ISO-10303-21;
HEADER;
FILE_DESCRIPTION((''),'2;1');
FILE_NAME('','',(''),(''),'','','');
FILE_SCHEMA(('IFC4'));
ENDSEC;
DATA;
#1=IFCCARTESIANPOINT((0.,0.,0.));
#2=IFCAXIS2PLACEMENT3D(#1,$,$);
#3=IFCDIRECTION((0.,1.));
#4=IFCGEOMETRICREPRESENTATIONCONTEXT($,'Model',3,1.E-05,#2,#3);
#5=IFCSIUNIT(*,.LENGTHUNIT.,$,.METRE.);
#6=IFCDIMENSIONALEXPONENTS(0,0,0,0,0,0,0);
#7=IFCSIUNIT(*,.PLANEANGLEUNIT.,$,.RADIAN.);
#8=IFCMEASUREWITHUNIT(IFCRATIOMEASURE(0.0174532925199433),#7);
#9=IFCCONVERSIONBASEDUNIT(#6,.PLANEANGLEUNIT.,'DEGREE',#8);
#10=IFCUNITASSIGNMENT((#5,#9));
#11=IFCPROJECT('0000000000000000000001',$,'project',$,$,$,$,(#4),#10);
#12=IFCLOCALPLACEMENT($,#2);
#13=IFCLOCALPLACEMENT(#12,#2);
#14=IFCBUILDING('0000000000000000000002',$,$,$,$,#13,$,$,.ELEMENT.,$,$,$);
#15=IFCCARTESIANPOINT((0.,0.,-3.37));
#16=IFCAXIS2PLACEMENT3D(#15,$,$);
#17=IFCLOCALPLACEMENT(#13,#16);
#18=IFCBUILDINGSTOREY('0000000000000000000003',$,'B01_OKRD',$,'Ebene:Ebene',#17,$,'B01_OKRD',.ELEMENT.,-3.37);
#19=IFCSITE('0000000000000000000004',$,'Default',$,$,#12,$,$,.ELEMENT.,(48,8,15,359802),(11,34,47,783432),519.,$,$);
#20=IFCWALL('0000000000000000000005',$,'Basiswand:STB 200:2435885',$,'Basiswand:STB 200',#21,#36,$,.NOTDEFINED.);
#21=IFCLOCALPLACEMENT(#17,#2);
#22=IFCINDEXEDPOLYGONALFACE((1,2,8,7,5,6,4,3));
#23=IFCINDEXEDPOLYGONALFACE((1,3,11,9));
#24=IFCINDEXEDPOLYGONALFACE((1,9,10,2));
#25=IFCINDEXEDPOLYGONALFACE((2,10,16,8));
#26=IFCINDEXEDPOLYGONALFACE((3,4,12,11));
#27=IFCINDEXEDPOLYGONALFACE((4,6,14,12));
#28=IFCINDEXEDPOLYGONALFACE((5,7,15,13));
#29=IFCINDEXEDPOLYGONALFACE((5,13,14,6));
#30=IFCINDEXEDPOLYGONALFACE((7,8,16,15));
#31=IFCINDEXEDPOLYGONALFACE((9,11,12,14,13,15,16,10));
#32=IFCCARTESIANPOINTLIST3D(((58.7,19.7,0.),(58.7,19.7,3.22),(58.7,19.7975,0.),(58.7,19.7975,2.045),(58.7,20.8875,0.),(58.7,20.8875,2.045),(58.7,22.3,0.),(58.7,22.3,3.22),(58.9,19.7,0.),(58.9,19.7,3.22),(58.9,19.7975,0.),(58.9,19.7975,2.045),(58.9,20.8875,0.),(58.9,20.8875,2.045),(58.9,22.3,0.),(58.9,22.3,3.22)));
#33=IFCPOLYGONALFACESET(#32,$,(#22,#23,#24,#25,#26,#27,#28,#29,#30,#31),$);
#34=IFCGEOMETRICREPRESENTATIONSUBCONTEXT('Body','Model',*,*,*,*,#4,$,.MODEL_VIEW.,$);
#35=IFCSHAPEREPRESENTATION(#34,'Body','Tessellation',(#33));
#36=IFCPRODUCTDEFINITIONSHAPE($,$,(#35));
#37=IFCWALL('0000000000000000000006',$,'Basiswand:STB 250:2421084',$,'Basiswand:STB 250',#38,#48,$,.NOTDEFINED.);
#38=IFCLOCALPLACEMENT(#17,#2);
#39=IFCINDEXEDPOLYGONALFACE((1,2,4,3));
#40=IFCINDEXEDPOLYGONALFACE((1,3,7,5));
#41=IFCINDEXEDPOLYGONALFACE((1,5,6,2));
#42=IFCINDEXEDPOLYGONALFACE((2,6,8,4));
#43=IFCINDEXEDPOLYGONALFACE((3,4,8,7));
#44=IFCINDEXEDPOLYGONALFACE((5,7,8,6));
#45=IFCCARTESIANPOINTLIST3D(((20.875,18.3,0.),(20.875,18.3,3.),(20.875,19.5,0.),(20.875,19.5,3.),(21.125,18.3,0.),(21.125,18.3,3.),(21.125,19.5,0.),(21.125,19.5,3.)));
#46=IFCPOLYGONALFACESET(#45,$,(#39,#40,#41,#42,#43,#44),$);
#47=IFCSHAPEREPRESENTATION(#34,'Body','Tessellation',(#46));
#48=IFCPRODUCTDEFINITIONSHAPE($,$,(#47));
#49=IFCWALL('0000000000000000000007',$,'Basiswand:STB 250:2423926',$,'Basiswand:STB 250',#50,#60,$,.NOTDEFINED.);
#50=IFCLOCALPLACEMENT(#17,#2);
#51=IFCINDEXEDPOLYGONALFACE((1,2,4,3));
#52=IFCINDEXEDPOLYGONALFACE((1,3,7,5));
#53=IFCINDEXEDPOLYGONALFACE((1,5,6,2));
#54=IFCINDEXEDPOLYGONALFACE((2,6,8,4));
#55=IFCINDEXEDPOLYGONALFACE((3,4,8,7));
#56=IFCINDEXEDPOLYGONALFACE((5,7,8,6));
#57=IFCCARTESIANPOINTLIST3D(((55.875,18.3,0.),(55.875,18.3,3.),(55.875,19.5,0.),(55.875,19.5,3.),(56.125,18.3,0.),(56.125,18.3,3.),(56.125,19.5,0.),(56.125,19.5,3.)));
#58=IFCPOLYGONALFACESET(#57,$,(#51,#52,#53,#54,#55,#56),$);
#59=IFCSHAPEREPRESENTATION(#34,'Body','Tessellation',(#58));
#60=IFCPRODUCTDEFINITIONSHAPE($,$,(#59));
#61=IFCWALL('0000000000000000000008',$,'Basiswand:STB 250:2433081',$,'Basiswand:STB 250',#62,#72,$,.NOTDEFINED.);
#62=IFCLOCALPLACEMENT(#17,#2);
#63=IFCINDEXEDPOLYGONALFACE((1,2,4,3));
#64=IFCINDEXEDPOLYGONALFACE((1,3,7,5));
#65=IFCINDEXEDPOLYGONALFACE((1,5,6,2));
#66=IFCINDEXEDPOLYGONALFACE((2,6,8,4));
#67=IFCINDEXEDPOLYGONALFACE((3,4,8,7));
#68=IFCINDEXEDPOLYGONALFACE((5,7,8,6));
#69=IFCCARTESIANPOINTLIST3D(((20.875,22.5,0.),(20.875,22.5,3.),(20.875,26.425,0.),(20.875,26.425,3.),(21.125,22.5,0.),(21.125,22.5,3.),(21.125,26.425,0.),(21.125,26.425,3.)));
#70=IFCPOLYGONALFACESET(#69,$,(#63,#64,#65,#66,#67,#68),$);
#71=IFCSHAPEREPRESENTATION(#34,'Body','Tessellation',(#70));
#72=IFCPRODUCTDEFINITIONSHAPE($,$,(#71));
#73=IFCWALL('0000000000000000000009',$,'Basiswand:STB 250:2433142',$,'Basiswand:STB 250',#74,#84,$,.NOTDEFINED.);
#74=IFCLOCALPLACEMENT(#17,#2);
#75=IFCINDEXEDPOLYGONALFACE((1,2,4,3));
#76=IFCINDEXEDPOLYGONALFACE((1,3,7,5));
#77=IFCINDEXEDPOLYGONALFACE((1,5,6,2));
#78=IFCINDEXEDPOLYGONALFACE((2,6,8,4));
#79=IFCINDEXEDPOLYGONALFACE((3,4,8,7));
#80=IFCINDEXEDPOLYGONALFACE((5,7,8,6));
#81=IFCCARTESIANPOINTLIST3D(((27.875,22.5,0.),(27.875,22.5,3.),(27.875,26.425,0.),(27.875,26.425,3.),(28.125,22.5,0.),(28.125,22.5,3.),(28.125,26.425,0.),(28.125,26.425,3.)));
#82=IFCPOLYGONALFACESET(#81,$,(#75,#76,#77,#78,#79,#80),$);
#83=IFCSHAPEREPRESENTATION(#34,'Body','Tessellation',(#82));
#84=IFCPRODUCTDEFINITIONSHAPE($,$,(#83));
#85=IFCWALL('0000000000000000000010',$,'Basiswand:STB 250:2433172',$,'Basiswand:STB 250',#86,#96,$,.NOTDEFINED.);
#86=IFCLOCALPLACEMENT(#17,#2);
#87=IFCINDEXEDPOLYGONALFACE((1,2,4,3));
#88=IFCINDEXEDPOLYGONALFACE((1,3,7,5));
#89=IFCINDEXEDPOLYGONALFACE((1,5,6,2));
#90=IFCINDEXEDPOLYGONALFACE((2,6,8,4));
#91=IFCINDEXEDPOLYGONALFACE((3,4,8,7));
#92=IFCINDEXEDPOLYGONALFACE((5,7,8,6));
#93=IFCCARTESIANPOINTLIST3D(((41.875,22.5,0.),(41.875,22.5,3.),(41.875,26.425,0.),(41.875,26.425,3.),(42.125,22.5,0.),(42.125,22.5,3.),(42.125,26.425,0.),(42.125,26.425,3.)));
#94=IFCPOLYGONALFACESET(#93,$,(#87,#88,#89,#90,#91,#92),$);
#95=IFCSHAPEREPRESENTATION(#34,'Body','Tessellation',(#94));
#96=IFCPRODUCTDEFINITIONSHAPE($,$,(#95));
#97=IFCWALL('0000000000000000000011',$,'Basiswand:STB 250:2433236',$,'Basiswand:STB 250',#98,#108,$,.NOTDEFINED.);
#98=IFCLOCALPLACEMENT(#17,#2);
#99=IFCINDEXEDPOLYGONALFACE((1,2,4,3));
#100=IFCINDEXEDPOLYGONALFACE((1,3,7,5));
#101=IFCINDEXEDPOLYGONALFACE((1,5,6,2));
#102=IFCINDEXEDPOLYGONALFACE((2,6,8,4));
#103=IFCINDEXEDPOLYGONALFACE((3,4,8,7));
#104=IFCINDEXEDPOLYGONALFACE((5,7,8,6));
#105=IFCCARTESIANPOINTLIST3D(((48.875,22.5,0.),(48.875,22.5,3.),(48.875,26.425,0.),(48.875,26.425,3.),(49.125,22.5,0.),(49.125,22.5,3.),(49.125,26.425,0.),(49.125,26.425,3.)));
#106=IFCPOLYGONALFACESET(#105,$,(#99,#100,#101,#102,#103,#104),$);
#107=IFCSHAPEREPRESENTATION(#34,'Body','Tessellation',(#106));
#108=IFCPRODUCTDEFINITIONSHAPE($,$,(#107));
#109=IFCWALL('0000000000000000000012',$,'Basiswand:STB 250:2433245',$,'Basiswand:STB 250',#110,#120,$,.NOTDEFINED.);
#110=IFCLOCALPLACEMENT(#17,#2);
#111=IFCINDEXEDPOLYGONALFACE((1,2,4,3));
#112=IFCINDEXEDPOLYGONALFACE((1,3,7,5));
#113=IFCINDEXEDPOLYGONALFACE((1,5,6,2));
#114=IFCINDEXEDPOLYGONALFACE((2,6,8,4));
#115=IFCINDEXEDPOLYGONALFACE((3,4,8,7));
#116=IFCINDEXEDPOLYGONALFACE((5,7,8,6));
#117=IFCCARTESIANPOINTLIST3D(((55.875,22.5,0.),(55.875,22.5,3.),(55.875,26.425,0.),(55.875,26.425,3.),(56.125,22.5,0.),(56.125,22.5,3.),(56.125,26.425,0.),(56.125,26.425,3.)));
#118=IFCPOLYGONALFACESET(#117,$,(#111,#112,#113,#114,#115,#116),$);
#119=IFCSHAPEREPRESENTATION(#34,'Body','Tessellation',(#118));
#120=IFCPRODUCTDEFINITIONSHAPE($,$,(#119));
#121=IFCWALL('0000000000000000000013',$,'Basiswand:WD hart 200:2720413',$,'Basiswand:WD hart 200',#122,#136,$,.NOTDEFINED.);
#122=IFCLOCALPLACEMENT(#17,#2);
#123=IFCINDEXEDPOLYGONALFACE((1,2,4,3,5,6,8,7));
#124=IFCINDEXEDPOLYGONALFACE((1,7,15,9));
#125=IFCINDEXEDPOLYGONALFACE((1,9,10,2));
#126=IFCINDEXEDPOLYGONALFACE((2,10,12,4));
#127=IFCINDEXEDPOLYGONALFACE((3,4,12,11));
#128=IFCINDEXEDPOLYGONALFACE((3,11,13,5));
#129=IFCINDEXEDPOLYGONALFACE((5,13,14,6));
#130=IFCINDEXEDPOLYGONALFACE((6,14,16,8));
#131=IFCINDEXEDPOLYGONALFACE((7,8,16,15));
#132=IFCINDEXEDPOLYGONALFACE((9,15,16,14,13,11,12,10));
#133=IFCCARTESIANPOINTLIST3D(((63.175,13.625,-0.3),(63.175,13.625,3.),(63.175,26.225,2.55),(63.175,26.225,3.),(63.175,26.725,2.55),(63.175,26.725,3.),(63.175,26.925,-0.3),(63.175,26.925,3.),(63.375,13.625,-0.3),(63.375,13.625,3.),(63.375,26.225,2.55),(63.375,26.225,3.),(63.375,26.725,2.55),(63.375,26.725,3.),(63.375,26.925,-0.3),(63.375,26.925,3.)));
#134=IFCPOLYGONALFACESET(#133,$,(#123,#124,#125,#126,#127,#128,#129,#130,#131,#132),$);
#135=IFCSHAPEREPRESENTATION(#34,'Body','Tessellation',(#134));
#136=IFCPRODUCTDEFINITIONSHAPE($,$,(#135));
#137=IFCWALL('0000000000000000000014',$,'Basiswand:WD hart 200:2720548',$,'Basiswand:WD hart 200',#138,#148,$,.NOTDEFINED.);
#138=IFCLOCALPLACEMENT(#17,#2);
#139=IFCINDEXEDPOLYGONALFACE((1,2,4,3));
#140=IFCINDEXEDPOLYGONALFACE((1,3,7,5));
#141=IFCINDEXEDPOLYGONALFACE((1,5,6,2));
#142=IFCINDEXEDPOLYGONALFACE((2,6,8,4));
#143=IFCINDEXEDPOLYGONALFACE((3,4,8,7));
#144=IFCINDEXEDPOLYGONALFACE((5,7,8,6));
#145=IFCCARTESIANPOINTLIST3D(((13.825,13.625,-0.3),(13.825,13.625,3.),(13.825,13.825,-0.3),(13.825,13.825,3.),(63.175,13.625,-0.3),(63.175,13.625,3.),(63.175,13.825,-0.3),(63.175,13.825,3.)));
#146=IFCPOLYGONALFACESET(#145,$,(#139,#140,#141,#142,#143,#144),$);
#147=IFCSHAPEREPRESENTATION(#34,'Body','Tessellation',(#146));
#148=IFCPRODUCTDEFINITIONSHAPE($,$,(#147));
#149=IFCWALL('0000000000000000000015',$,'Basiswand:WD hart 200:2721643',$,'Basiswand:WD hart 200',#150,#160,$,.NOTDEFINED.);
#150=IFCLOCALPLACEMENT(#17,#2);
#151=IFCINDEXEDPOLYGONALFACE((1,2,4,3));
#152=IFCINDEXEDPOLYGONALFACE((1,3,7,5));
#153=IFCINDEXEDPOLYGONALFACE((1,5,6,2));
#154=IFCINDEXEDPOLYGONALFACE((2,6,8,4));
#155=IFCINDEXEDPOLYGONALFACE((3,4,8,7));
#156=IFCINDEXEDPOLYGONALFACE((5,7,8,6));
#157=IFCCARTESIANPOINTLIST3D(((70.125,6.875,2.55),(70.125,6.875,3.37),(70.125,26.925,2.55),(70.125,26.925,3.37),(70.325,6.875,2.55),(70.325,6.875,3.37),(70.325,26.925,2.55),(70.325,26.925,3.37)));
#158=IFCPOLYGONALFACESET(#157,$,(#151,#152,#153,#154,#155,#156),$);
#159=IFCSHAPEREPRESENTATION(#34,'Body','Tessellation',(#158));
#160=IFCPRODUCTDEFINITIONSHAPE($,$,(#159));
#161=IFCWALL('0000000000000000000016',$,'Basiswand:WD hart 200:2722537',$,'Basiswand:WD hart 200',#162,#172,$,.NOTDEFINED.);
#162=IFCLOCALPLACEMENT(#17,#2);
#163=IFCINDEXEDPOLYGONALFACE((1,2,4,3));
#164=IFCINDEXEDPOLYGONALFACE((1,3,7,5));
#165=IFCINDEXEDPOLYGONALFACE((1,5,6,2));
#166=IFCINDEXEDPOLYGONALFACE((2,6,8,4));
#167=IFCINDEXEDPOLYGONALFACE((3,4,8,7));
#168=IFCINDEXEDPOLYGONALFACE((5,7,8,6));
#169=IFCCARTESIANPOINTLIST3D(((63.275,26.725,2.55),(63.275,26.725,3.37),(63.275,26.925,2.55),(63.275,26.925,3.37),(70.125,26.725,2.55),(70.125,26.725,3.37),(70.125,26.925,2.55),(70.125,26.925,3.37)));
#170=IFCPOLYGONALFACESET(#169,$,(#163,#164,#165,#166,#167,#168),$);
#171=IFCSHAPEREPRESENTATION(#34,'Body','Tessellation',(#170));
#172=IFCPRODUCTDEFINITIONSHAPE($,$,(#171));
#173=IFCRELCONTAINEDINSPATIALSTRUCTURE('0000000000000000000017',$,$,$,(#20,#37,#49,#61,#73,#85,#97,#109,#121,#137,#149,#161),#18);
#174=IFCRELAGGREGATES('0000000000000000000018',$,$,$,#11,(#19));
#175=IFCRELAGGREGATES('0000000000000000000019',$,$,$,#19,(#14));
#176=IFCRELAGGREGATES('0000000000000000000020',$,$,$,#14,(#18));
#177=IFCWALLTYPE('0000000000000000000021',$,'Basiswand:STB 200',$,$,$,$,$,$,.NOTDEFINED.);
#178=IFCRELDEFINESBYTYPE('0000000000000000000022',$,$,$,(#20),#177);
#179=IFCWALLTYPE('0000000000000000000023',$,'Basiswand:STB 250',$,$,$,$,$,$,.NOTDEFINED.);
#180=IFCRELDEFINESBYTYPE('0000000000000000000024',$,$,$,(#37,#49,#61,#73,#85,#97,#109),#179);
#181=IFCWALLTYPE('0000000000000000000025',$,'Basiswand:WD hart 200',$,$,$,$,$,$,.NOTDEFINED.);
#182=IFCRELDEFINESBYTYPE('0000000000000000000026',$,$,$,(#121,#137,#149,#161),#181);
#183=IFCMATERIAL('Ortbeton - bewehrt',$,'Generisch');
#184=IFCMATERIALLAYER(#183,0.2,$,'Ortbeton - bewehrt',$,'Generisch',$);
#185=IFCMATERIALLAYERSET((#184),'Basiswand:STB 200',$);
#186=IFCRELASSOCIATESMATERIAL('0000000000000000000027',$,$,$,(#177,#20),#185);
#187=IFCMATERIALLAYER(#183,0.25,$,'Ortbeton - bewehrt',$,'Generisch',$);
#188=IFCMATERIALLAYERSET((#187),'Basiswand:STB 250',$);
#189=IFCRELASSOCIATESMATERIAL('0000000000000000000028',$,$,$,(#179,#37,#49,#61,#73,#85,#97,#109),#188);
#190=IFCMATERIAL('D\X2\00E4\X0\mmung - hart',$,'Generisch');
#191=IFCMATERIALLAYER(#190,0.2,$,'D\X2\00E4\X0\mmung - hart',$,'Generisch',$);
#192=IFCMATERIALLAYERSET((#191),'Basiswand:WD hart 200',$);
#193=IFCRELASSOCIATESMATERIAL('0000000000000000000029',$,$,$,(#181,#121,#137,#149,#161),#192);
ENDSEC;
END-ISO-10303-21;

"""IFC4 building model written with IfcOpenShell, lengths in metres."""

from ifc_helpers import new_model, entity, si_unit, converted_unit, direction, frame, frame_2d, origin, place, context, subcontext, project, spatial, rectangle, extrude, material, layer, layer_set, layer_usage, type_object, element, save


model = new_model("IFC4")

# Units and contexts
model_context = context("Model", 3, precision=1e-05, world=origin(), true_north=direction((0.0, 1.0)))
body_context = subcontext(model_context, "Body", "Model", "MODEL_VIEW")
ifc_project = project(units=[si_unit("LENGTHUNIT", "METRE"), converted_unit("PLANEANGLEUNIT", "DEGREE", entity("IfcRatioMeasure", 0.0174532925199433), si_unit("PLANEANGLEUNIT", "RADIAN"), dimensions=[0, 0, 0, 0, 0, 0, 0])], contexts=[model_context])

# Site, building, storey
site_placement = place(None, frame((0.0, 0.0, 0.0)))
site = spatial("IfcSite", under=ifc_project, at=site_placement, Name="Default", CompositionType="ELEMENT", RefLatitude=(48, 8, 15, 359802), RefLongitude=(11, 34, 47, 783432), RefElevation=519.0)
building_placement = place(site_placement, origin())
building = spatial("IfcBuilding", under=site, at=building_placement, CompositionType="ELEMENT")
storey_placement = place(building_placement, frame((0.0, 0.0, -3.37)))
storey = spatial("IfcBuildingStorey", under=building, at=storey_placement, Name="B01_OKRD", ObjectType="Ebene:Ebene", LongName="B01_OKRD", CompositionType="ELEMENT", Elevation=-3.37)

# Shared definitions
ifc_material_1 = material(Name="Ortbeton - bewehrt", Category="Generisch")
ifc_layer_1 = layer(ifc_material_1, 0.2, Name="Ortbeton - bewehrt", Category="Generisch")
ifc_layer_set_1 = layer_set([ifc_layer_1], Name="Basiswand:STB 200")
wall_type_1 = type_object("IfcWallType", Name="Basiswand:STB 200", PredefinedType="NOTDEFINED", material=ifc_layer_set_1)

# Wall, opening
ifc_layer_usage_1 = layer_usage(ifc_layer_set_1, "AXIS2", "NEGATIVE", 0.1)
wall_1_placement = place(storey_placement, frame((58.8, 19.7, 0.0), z_axis=(0.0, 0.0, 1.0), x_axis=(0.0, 1.0, 0.0)))
wall_1 = element("IfcWall", 1, at=wall_1_placement, inside=storey, type_object=wall_type_1, material=ifc_layer_usage_1, Name="Basiswand:STB 200:2435885", ObjectType="Basiswand:STB 200", PredefinedType="NOTDEFINED", context=body_context, shape_type="SweptSolid", body=[
    extrude(rectangle(XDim=2.6, YDim=0.2, at=frame_2d((1.3, 0.0), x_axis=(-1.0, 0.0))), origin(), (0.0, 0.0, 1.0), 3.22),
])
opening_1_placement = place(wall_1_placement, frame((1.1875, 0.1, -0.18)))
element("IfcOpeningElement", 2, at=opening_1_placement, cuts=wall_1, ObjectType="Opening", PredefinedType="OPENING", context=body_context, shape_type="SweptSolid", body=[
    extrude(rectangle(XDim=2.225, YDim=1.09, at=frame_2d((1.1125, 0.545), x_axis=(-1.0, 0.0))), frame((0.0, 0.0, 0.0), z_axis=(0.0, -1.0, 0.0), x_axis=(0.0, 0.0, 1.0)), (0.0, 0.0, 1.0), 0.2),
])

# Walls
ifc_layer_2 = layer(ifc_material_1, 0.25, Name="Ortbeton - bewehrt", Category="Generisch")
ifc_layer_set_2 = layer_set([ifc_layer_2], Name="Basiswand:STB 250")
ifc_layer_usage_2 = layer_usage(ifc_layer_set_2, "AXIS2", "POSITIVE", -0.125)
wall_type_2 = type_object("IfcWallType", Name="Basiswand:STB 250", PredefinedType="NOTDEFINED", material=ifc_layer_set_2)
wall_2_placement = place(storey_placement, frame((21.0, 19.5, 0.0), z_axis=(0.0, 0.0, 1.0), x_axis=(0.0, -1.0, 0.0)))
element("IfcWall", 3, at=wall_2_placement, inside=storey, type_object=wall_type_2, material=ifc_layer_usage_2, Name="Basiswand:STB 250:2421084", ObjectType="Basiswand:STB 250", PredefinedType="NOTDEFINED", context=body_context, shape_type="SweptSolid", body=[
    extrude(rectangle(XDim=1.2, YDim=0.25, at=frame_2d((0.6, 0.0), x_axis=(-1.0, 0.0))), origin(), (0.0, 0.0, 1.0), 3.0),
])
ifc_layer_usage_3 = layer_usage(ifc_layer_set_2, "AXIS2", "NEGATIVE", 0.125)
wall_3_placement = place(storey_placement, frame((56.0, 19.5, 0.0), z_axis=(0.0, 0.0, 1.0), x_axis=(0.0, -1.0, 0.0)))
element("IfcWall", 4, at=wall_3_placement, inside=storey, type_object=wall_type_2, material=ifc_layer_usage_3, Name="Basiswand:STB 250:2423926", ObjectType="Basiswand:STB 250", PredefinedType="NOTDEFINED", context=body_context, shape_type="SweptSolid", body=[
    extrude(rectangle(XDim=1.2, YDim=0.25, at=frame_2d((0.6, 0.0), x_axis=(-1.0, 0.0))), origin(), (0.0, 0.0, 1.0), 3.0),
])
ifc_layer_usage_4 = layer_usage(ifc_layer_set_2, "AXIS2", "POSITIVE", -0.125)
wall_4_placement = place(storey_placement, frame((21.0, 26.425, 0.0), z_axis=(0.0, 0.0, 1.0), x_axis=(0.0, -1.0, 0.0)))
element("IfcWall", 5, at=wall_4_placement, inside=storey, type_object=wall_type_2, material=ifc_layer_usage_4, Name="Basiswand:STB 250:2433081", ObjectType="Basiswand:STB 250", PredefinedType="NOTDEFINED", context=body_context, shape_type="SweptSolid", body=[
    extrude(rectangle(XDim=3.925, YDim=0.25, at=frame_2d((1.9625, 0.0), x_axis=(-1.0, 0.0))), origin(), (0.0, 0.0, 1.0), 3.0),
])
ifc_layer_usage_5 = layer_usage(ifc_layer_set_2, "AXIS2", "POSITIVE", -0.125)
wall_5_placement = place(storey_placement, frame((28.0, 26.425, 0.0), z_axis=(0.0, 0.0, 1.0), x_axis=(0.0, -1.0, 0.0)))
element("IfcWall", 6, at=wall_5_placement, inside=storey, type_object=wall_type_2, material=ifc_layer_usage_5, Name="Basiswand:STB 250:2433142", ObjectType="Basiswand:STB 250", PredefinedType="NOTDEFINED", context=body_context, shape_type="SweptSolid", body=[
    extrude(rectangle(XDim=3.925, YDim=0.25, at=frame_2d((1.9625, 0.0), x_axis=(-1.0, 0.0))), origin(), (0.0, 0.0, 1.0), 3.0),
])
ifc_layer_usage_6 = layer_usage(ifc_layer_set_2, "AXIS2", "POSITIVE", -0.125)
wall_6_placement = place(storey_placement, frame((42.0, 26.425, 0.0), z_axis=(0.0, 0.0, 1.0), x_axis=(0.0, -1.0, 0.0)))
element("IfcWall", 7, at=wall_6_placement, inside=storey, type_object=wall_type_2, material=ifc_layer_usage_6, Name="Basiswand:STB 250:2433172", ObjectType="Basiswand:STB 250", PredefinedType="NOTDEFINED", context=body_context, shape_type="SweptSolid", body=[
    extrude(rectangle(XDim=3.925, YDim=0.25, at=frame_2d((1.9625, 0.0), x_axis=(-1.0, 0.0))), origin(), (0.0, 0.0, 1.0), 3.0),
])
ifc_layer_usage_7 = layer_usage(ifc_layer_set_2, "AXIS2", "POSITIVE", -0.125)
wall_7_placement = place(storey_placement, frame((49.0, 26.425, 0.0), z_axis=(0.0, 0.0, 1.0), x_axis=(0.0, -1.0, 0.0)))
element("IfcWall", 8, at=wall_7_placement, inside=storey, type_object=wall_type_2, material=ifc_layer_usage_7, Name="Basiswand:STB 250:2433236", ObjectType="Basiswand:STB 250", PredefinedType="NOTDEFINED", context=body_context, shape_type="SweptSolid", body=[
    extrude(rectangle(XDim=3.925, YDim=0.25, at=frame_2d((1.9625, 0.0), x_axis=(-1.0, 0.0))), origin(), (0.0, 0.0, 1.0), 3.0),
])
ifc_layer_usage_8 = layer_usage(ifc_layer_set_2, "AXIS2", "POSITIVE", -0.125)
wall_8_placement = place(storey_placement, frame((56.0, 26.425, 0.0), z_axis=(0.0, 0.0, 1.0), x_axis=(0.0, -1.0, 0.0)))
element("IfcWall", 9, at=wall_8_placement, inside=storey, type_object=wall_type_2, material=ifc_layer_usage_8, Name="Basiswand:STB 250:2433245", ObjectType="Basiswand:STB 250", PredefinedType="NOTDEFINED", context=body_context, shape_type="SweptSolid", body=[
    extrude(rectangle(XDim=3.925, YDim=0.25, at=frame_2d((1.9625, 0.0), x_axis=(-1.0, 0.0))), origin(), (0.0, 0.0, 1.0), 3.0),
])

# Wall, opening
ifc_material_2 = material(Name="Dämmung - hart", Category="Generisch")
ifc_layer_3 = layer(ifc_material_2, 0.2, Name="Dämmung - hart", Category="Generisch")
ifc_layer_set_3 = layer_set([ifc_layer_3], Name="Basiswand:WD hart 200")
ifc_layer_usage_9 = layer_usage(ifc_layer_set_3, "AXIS2", "POSITIVE", -0.1)
wall_type_3 = type_object("IfcWallType", Name="Basiswand:WD hart 200", PredefinedType="NOTDEFINED", material=ifc_layer_set_3)
wall_9_placement = place(storey_placement, frame((63.275, 26.925, -0.3), z_axis=(0.0, 0.0, 1.0), x_axis=(0.0, -1.0, 0.0)))
wall_9 = element("IfcWall", 10, at=wall_9_placement, inside=storey, type_object=wall_type_3, material=ifc_layer_usage_9, Name="Basiswand:WD hart 200:2720413", ObjectType="Basiswand:WD hart 200", PredefinedType="NOTDEFINED", context=body_context, shape_type="SweptSolid", body=[
    extrude(rectangle(XDim=13.3, YDim=0.2, at=frame_2d((6.65, 0.0), x_axis=(-1.0, 0.0))), origin(), (0.0, 0.0, 1.0), 3.3),
])
opening_2_placement = place(wall_9_placement, frame((0.7, -0.1, 2.85)))
element("IfcOpeningElement", 11, at=opening_2_placement, cuts=wall_9, ObjectType="Opening", PredefinedType="OPENING", context=body_context, shape_type="SweptSolid", body=[
    extrude(rectangle(XDim=0.45, YDim=0.5, at=frame_2d((0.0, 0.0), x_axis=(1.0, 0.0))), frame((-0.25, 0.0, 0.225), z_axis=(0.0, 1.0, 0.0), x_axis=(0.0, 0.0, -1.0)), (0.0, 0.0, 1.0), 0.2),
])

# Walls
ifc_layer_usage_10 = layer_usage(ifc_layer_set_3, "AXIS2", "POSITIVE", -0.1)
wall_10_placement = place(storey_placement, frame((63.175, 13.725, -0.3), z_axis=(0.0, 0.0, 1.0), x_axis=(-1.0, 0.0, 0.0)))
element("IfcWall", 12, at=wall_10_placement, inside=storey, type_object=wall_type_3, material=ifc_layer_usage_10, Name="Basiswand:WD hart 200:2720548", ObjectType="Basiswand:WD hart 200", PredefinedType="NOTDEFINED", context=body_context, shape_type="SweptSolid", body=[
    extrude(rectangle(XDim=49.35, YDim=0.2, at=frame_2d((24.675, 0.0), x_axis=(-1.0, 0.0))), origin(), (0.0, 0.0, 1.0), 3.3),
])
ifc_layer_usage_11 = layer_usage(ifc_layer_set_3, "AXIS2", "NEGATIVE", 0.1)
wall_11_placement = place(storey_placement, frame((70.225, 6.875, 2.55), z_axis=(0.0, 0.0, 1.0), x_axis=(0.0, 1.0, 0.0)))
element("IfcWall", 13, at=wall_11_placement, inside=storey, type_object=wall_type_3, material=ifc_layer_usage_11, Name="Basiswand:WD hart 200:2721643", ObjectType="Basiswand:WD hart 200", PredefinedType="NOTDEFINED", context=body_context, shape_type="SweptSolid", body=[
    extrude(rectangle(XDim=20.05, YDim=0.2, at=frame_2d((10.025, 0.0), x_axis=(-1.0, 0.0))), origin(), (0.0, 0.0, 1.0), 0.82),
])
ifc_layer_usage_12 = layer_usage(ifc_layer_set_3, "AXIS2", "NEGATIVE", 0.1)
wall_12_placement = place(storey_placement, frame((70.125, 26.825, 2.55), z_axis=(0.0, 0.0, 1.0), x_axis=(-1.0, 0.0, 0.0)))
element("IfcWall", 14, at=wall_12_placement, inside=storey, type_object=wall_type_3, material=ifc_layer_usage_12, Name="Basiswand:WD hart 200:2722537", ObjectType="Basiswand:WD hart 200", PredefinedType="NOTDEFINED", context=body_context, shape_type="SweptSolid", body=[
    extrude(rectangle(XDim=6.85, YDim=0.2, at=frame_2d((3.425, 0.0), x_axis=(-1.0, 0.0))), origin(), (0.0, 0.0, 1.0), 0.82),
])

save(model, "model.ifc")
